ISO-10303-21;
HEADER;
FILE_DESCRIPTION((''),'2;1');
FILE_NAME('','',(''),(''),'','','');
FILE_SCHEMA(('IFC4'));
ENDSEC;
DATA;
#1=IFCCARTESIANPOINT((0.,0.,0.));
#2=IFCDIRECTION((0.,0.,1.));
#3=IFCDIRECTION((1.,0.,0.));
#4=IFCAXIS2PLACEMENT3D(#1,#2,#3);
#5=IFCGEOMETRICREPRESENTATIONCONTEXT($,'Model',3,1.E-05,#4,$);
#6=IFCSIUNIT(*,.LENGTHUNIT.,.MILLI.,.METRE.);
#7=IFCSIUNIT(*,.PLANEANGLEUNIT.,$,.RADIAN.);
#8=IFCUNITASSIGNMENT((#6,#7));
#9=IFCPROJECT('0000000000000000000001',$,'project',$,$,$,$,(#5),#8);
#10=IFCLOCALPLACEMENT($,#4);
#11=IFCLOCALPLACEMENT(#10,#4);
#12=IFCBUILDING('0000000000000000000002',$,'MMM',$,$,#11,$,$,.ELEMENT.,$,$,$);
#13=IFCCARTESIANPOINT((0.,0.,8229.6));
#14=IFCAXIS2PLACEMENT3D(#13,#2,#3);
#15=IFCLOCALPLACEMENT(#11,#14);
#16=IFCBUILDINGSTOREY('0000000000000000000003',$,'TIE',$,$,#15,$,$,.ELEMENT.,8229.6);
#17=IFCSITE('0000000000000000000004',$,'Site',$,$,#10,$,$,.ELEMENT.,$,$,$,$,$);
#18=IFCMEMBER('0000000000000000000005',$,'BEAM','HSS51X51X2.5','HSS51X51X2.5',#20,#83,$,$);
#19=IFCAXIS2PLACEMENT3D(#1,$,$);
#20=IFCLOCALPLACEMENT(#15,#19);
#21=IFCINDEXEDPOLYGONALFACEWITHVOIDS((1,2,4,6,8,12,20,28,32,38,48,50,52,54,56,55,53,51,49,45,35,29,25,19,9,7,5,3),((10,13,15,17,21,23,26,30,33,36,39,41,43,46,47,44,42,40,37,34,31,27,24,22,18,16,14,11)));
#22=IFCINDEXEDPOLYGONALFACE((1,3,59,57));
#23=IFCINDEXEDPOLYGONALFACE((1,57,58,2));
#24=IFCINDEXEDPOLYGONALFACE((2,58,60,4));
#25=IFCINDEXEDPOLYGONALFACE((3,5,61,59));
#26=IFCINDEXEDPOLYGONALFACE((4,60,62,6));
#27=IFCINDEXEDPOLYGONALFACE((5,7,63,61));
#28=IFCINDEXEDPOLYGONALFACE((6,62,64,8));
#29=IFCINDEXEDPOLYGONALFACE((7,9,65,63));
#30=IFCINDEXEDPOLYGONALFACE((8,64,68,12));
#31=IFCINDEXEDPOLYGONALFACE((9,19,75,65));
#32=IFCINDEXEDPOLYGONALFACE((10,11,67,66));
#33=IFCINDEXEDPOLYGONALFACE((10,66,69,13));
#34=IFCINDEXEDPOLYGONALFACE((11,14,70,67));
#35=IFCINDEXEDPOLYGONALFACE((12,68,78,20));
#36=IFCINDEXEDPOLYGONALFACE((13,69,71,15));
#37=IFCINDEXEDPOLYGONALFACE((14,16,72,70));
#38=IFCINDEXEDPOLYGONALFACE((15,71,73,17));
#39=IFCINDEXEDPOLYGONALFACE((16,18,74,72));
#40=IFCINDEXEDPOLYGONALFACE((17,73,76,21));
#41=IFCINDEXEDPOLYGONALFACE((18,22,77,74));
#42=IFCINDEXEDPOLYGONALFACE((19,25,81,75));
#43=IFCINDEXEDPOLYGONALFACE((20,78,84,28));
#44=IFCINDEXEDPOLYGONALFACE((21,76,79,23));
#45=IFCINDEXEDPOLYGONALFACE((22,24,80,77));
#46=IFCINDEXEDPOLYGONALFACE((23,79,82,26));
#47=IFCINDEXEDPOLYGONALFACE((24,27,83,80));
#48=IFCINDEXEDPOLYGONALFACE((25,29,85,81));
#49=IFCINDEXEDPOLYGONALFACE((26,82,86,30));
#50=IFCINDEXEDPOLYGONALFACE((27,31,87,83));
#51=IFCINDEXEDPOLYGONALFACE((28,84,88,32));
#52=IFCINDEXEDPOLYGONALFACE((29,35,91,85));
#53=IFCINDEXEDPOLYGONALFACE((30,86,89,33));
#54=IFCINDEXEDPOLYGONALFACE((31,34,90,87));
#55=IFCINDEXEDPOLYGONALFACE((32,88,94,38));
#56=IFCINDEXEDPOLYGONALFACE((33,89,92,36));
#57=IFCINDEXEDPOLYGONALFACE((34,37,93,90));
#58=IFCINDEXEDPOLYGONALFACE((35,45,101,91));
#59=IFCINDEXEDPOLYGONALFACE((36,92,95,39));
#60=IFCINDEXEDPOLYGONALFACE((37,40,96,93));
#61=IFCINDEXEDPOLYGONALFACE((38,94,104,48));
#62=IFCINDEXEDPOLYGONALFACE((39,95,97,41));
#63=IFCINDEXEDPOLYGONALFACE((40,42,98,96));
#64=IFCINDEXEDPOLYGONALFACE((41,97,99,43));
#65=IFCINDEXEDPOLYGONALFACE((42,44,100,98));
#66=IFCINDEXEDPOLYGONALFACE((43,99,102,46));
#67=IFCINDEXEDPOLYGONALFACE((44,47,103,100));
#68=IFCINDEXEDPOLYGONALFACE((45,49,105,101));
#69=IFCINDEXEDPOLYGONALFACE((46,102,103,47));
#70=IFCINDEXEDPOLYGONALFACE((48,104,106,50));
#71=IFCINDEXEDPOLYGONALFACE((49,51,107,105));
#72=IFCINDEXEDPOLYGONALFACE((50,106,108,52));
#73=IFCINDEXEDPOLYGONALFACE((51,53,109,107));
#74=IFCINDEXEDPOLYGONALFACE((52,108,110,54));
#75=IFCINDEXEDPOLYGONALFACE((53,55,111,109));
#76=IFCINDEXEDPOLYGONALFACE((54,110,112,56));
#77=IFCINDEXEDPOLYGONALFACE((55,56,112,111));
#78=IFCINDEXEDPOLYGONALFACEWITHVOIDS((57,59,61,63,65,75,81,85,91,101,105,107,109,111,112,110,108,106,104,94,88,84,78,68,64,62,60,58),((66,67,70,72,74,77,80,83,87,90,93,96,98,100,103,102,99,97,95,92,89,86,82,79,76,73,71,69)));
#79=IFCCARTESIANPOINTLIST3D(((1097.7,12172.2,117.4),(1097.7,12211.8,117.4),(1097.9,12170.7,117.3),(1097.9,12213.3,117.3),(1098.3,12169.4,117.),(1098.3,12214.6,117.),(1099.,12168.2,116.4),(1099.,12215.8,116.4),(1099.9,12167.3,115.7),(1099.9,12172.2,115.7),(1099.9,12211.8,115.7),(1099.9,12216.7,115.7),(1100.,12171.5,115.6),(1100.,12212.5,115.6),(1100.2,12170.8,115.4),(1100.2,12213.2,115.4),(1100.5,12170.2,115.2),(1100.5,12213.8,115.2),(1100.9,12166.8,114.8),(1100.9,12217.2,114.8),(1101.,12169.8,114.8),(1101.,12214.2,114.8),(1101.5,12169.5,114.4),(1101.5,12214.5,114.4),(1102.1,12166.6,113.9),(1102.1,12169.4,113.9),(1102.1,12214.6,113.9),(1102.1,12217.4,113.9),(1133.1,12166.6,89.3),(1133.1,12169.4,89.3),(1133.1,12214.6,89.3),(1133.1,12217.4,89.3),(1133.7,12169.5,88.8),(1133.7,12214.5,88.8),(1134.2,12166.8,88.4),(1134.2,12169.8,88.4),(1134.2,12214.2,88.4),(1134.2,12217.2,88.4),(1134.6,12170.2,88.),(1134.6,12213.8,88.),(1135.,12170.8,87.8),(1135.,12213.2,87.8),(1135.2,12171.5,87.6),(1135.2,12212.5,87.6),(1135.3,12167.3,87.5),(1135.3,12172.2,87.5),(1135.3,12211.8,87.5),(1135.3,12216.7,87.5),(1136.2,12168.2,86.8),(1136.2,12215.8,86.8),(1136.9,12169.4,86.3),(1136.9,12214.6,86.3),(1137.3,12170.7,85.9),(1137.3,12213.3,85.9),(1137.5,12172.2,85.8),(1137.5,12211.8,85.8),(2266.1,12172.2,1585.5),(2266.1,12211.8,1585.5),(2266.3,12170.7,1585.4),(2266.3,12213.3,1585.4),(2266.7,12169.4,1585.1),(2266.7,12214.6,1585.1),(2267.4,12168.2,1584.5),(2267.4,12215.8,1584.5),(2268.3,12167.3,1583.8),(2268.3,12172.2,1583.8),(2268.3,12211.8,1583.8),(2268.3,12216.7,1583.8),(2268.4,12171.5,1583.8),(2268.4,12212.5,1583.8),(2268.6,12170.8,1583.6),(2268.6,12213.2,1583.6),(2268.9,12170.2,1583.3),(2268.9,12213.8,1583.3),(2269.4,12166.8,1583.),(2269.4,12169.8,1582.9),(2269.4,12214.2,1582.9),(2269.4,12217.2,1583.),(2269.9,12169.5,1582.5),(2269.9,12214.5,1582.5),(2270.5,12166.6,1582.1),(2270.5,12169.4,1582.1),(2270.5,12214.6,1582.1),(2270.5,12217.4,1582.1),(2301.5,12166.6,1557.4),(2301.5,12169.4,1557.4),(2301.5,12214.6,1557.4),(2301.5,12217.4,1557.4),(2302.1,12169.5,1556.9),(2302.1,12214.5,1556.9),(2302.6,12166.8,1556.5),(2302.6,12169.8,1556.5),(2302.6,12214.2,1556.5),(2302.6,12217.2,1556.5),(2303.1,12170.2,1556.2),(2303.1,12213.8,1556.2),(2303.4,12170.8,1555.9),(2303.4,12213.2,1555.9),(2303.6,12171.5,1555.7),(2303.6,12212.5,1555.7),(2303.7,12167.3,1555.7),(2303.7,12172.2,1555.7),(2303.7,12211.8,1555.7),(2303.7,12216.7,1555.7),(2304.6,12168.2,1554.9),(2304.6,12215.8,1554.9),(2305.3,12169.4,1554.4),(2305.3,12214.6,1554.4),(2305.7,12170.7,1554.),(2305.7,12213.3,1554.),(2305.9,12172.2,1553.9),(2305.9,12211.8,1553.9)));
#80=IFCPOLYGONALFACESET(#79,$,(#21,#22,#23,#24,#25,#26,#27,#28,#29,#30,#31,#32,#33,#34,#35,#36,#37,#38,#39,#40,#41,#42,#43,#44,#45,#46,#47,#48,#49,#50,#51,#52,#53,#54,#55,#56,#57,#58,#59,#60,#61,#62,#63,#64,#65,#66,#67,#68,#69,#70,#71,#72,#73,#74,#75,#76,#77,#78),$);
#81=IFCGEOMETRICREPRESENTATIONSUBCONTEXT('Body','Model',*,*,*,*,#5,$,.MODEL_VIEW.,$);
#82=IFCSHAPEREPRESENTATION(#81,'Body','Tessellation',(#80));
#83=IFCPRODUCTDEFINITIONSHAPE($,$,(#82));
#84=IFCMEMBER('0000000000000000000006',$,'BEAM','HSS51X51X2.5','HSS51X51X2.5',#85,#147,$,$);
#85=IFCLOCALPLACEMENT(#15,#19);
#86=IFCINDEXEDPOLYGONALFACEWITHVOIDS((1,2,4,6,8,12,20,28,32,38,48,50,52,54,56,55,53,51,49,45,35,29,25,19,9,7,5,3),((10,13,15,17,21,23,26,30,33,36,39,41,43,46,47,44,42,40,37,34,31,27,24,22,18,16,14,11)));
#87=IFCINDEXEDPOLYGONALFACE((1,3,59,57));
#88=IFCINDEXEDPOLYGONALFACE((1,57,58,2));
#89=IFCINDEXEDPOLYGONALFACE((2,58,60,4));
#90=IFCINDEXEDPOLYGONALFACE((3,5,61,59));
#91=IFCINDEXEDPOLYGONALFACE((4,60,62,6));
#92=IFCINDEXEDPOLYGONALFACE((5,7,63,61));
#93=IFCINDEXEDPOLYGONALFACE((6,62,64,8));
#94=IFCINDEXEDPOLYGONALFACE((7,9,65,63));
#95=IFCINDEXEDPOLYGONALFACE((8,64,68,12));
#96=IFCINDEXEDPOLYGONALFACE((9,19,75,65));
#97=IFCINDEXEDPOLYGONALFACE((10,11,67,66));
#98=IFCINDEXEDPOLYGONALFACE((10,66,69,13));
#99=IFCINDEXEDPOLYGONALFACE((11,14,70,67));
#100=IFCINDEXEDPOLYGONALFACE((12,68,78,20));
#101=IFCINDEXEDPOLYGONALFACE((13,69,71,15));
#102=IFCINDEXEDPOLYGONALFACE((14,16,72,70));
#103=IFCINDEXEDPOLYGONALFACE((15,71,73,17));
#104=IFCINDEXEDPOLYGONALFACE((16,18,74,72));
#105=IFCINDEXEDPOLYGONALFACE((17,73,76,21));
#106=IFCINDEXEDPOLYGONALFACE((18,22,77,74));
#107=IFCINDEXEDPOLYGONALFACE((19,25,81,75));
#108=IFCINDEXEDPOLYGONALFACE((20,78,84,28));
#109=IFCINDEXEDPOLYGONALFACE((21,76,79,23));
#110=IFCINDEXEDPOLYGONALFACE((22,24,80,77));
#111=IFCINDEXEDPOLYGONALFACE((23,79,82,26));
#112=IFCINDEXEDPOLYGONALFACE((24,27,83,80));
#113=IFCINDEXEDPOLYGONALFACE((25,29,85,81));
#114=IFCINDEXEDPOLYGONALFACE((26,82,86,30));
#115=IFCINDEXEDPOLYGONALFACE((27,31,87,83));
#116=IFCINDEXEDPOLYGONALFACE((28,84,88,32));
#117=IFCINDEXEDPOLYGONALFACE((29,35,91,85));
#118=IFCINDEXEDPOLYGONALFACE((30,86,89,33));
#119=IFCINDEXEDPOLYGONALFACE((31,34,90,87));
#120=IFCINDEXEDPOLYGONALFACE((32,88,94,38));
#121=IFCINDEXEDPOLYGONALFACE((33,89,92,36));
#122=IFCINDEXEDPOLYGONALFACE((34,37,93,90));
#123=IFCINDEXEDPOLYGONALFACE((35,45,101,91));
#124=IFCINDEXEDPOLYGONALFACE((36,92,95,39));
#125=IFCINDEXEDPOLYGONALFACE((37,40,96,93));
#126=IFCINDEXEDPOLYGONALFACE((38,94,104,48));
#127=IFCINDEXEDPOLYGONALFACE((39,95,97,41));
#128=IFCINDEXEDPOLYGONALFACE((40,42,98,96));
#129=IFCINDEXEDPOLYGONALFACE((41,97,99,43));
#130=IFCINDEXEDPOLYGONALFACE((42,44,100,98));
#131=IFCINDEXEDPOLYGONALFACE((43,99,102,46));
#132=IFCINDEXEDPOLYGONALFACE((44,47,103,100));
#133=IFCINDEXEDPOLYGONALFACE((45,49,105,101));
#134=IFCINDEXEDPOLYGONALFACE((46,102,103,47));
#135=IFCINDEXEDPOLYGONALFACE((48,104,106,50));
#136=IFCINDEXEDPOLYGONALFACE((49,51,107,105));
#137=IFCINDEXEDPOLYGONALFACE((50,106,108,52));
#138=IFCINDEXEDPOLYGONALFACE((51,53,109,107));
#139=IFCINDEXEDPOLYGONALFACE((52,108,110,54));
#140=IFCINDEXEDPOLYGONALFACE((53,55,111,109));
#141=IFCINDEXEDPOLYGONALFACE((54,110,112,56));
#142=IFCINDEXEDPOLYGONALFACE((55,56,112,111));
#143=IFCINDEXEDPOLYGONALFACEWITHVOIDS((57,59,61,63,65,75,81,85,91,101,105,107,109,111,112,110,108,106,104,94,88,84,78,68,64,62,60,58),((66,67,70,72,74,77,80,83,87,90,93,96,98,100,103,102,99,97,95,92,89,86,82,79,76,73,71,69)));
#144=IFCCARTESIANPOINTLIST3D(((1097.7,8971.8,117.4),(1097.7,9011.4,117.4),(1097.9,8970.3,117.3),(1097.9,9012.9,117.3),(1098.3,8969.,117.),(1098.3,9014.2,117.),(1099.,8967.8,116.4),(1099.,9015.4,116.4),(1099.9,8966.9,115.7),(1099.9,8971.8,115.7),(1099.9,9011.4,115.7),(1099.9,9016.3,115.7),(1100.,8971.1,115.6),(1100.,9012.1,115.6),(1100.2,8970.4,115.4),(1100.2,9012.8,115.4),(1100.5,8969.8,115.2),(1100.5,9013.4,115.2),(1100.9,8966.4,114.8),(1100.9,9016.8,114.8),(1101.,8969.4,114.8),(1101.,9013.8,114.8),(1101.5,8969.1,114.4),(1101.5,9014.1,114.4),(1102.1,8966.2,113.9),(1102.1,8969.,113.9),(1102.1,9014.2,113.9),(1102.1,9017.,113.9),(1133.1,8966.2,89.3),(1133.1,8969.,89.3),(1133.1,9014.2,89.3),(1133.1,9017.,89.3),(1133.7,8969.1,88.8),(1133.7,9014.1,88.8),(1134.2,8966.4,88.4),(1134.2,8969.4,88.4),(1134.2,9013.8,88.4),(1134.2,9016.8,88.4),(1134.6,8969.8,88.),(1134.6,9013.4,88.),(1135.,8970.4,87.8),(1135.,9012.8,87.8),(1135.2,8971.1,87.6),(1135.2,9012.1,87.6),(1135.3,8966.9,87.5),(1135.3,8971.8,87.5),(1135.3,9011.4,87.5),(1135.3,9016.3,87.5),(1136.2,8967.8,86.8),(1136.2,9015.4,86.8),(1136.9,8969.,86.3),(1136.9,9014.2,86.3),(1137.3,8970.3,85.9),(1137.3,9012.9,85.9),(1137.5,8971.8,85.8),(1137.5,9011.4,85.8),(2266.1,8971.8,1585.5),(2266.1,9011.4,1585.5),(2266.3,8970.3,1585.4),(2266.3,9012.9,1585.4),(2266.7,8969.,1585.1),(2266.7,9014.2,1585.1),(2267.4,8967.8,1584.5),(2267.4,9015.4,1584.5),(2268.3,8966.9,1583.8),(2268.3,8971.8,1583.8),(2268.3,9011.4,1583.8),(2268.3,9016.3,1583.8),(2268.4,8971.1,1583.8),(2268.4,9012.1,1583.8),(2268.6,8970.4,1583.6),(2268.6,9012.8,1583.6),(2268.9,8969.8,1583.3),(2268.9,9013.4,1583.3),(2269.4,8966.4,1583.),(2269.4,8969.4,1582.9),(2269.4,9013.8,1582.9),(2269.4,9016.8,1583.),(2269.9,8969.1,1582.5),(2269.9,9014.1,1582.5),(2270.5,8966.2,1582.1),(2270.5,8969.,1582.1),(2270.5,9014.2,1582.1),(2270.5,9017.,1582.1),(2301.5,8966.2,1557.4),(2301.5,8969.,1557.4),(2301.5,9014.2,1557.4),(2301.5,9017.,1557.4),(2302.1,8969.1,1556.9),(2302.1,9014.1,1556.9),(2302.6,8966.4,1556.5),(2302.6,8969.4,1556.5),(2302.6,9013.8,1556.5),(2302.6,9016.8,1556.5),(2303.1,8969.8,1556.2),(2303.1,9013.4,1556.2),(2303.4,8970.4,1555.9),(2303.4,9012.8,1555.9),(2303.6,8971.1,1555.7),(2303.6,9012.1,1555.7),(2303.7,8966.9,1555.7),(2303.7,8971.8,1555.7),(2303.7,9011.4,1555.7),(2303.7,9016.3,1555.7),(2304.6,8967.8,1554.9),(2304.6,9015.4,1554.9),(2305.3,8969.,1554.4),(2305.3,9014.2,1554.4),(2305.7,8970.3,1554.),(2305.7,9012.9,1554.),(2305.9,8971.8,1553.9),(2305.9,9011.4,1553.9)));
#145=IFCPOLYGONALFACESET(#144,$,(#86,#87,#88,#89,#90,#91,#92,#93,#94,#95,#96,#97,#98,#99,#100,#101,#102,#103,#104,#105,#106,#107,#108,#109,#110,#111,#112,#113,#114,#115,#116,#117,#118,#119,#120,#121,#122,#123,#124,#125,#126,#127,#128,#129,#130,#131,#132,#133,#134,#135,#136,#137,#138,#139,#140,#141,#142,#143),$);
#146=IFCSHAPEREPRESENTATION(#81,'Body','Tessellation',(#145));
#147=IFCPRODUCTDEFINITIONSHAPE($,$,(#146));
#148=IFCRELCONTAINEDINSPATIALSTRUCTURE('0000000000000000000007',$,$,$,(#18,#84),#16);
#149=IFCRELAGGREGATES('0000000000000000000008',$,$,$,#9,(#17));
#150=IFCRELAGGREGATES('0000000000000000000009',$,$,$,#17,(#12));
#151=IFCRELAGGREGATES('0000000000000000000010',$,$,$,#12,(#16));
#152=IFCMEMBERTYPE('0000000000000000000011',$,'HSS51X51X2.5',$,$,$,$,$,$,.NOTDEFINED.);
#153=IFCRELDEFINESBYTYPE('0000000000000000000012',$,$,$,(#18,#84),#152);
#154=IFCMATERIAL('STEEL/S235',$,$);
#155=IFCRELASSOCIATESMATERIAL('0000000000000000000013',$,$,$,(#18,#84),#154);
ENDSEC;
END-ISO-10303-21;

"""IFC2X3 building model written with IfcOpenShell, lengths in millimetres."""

from ifc_helpers import new_model, si_unit, frame, origin_with_axes, origin_2d_with_axis, place, context, subcontext, project, spatial, hollow_rectangle, extrude, material, type_object, element, save


model = new_model("IFC2X3")

# Units and contexts
model_context = context("Model", 3, precision=1e-05, world=origin_with_axes())
body_context = subcontext(model_context, "Body", "Model", "MODEL_VIEW")
ifc_project = project(units=[si_unit("LENGTHUNIT", "METRE", prefix="MILLI"), si_unit("PLANEANGLEUNIT", "RADIAN")], contexts=[model_context])

# Site, building, storey
site_placement = place(None, origin_with_axes())
site = spatial("IfcSite", under=ifc_project, at=site_placement, Name="Site", CompositionType="ELEMENT")
building_placement = place(site_placement, origin_with_axes())
building = spatial("IfcBuilding", under=site, at=building_placement, Name="MMM", CompositionType="ELEMENT")
storey_placement = place(building_placement, frame((0.0, 0.0, 8229.6), z_axis=(0.0, 0.0, 1.0), x_axis=(1.0, 0.0, 0.0)))
storey = spatial("IfcBuildingStorey", under=building, at=storey_placement, Name="TIE", CompositionType="ELEMENT", Elevation=8229.6)

# Shared definitions
ifc_material = material(Name="STEEL/S235")

# Members
member_type_1 = type_object("IfcMemberType", Name="HSS51X51X2.5", PredefinedType="NOTDEFINED")
for number, where, z_axis, x_axis, name in (
    (1, (1117.6, 12192.0, 101.6), (-0.782448, 0.0, 0.622716), (0.622716, 0.0, 0.782448), "BEAM"),
    (2, (1117.6, 8991.6, 101.6), (-0.782448, 0.0, 0.622716), (0.622716, 0.0, 0.782448), "BEAM"),
):
    element("IfcMember", number, at=place(storey_placement, frame(where, z_axis=z_axis, x_axis=x_axis)), inside=storey, type_object=member_type_1, material=ifc_material, Name=name, Description="HSS51X51X2.5", ObjectType="HSS51X51X2.5", context=body_context, shape_type="SweptSolid", body=[
        extrude(hollow_rectangle(XDim=50.8, YDim=50.8, WallThickness=2.8, InnerFilletRadius=2.8, OuterFilletRadius=5.6, at=origin_2d_with_axis()), frame((1876.3, 0.0, 0.0), z_axis=(-1.0, 0.0, 0.0), x_axis=(0.0, -1.0, 0.0)), (0.0, 0.0, 1.0), 1876.3),
    ])

save(model, "model.ifc")
